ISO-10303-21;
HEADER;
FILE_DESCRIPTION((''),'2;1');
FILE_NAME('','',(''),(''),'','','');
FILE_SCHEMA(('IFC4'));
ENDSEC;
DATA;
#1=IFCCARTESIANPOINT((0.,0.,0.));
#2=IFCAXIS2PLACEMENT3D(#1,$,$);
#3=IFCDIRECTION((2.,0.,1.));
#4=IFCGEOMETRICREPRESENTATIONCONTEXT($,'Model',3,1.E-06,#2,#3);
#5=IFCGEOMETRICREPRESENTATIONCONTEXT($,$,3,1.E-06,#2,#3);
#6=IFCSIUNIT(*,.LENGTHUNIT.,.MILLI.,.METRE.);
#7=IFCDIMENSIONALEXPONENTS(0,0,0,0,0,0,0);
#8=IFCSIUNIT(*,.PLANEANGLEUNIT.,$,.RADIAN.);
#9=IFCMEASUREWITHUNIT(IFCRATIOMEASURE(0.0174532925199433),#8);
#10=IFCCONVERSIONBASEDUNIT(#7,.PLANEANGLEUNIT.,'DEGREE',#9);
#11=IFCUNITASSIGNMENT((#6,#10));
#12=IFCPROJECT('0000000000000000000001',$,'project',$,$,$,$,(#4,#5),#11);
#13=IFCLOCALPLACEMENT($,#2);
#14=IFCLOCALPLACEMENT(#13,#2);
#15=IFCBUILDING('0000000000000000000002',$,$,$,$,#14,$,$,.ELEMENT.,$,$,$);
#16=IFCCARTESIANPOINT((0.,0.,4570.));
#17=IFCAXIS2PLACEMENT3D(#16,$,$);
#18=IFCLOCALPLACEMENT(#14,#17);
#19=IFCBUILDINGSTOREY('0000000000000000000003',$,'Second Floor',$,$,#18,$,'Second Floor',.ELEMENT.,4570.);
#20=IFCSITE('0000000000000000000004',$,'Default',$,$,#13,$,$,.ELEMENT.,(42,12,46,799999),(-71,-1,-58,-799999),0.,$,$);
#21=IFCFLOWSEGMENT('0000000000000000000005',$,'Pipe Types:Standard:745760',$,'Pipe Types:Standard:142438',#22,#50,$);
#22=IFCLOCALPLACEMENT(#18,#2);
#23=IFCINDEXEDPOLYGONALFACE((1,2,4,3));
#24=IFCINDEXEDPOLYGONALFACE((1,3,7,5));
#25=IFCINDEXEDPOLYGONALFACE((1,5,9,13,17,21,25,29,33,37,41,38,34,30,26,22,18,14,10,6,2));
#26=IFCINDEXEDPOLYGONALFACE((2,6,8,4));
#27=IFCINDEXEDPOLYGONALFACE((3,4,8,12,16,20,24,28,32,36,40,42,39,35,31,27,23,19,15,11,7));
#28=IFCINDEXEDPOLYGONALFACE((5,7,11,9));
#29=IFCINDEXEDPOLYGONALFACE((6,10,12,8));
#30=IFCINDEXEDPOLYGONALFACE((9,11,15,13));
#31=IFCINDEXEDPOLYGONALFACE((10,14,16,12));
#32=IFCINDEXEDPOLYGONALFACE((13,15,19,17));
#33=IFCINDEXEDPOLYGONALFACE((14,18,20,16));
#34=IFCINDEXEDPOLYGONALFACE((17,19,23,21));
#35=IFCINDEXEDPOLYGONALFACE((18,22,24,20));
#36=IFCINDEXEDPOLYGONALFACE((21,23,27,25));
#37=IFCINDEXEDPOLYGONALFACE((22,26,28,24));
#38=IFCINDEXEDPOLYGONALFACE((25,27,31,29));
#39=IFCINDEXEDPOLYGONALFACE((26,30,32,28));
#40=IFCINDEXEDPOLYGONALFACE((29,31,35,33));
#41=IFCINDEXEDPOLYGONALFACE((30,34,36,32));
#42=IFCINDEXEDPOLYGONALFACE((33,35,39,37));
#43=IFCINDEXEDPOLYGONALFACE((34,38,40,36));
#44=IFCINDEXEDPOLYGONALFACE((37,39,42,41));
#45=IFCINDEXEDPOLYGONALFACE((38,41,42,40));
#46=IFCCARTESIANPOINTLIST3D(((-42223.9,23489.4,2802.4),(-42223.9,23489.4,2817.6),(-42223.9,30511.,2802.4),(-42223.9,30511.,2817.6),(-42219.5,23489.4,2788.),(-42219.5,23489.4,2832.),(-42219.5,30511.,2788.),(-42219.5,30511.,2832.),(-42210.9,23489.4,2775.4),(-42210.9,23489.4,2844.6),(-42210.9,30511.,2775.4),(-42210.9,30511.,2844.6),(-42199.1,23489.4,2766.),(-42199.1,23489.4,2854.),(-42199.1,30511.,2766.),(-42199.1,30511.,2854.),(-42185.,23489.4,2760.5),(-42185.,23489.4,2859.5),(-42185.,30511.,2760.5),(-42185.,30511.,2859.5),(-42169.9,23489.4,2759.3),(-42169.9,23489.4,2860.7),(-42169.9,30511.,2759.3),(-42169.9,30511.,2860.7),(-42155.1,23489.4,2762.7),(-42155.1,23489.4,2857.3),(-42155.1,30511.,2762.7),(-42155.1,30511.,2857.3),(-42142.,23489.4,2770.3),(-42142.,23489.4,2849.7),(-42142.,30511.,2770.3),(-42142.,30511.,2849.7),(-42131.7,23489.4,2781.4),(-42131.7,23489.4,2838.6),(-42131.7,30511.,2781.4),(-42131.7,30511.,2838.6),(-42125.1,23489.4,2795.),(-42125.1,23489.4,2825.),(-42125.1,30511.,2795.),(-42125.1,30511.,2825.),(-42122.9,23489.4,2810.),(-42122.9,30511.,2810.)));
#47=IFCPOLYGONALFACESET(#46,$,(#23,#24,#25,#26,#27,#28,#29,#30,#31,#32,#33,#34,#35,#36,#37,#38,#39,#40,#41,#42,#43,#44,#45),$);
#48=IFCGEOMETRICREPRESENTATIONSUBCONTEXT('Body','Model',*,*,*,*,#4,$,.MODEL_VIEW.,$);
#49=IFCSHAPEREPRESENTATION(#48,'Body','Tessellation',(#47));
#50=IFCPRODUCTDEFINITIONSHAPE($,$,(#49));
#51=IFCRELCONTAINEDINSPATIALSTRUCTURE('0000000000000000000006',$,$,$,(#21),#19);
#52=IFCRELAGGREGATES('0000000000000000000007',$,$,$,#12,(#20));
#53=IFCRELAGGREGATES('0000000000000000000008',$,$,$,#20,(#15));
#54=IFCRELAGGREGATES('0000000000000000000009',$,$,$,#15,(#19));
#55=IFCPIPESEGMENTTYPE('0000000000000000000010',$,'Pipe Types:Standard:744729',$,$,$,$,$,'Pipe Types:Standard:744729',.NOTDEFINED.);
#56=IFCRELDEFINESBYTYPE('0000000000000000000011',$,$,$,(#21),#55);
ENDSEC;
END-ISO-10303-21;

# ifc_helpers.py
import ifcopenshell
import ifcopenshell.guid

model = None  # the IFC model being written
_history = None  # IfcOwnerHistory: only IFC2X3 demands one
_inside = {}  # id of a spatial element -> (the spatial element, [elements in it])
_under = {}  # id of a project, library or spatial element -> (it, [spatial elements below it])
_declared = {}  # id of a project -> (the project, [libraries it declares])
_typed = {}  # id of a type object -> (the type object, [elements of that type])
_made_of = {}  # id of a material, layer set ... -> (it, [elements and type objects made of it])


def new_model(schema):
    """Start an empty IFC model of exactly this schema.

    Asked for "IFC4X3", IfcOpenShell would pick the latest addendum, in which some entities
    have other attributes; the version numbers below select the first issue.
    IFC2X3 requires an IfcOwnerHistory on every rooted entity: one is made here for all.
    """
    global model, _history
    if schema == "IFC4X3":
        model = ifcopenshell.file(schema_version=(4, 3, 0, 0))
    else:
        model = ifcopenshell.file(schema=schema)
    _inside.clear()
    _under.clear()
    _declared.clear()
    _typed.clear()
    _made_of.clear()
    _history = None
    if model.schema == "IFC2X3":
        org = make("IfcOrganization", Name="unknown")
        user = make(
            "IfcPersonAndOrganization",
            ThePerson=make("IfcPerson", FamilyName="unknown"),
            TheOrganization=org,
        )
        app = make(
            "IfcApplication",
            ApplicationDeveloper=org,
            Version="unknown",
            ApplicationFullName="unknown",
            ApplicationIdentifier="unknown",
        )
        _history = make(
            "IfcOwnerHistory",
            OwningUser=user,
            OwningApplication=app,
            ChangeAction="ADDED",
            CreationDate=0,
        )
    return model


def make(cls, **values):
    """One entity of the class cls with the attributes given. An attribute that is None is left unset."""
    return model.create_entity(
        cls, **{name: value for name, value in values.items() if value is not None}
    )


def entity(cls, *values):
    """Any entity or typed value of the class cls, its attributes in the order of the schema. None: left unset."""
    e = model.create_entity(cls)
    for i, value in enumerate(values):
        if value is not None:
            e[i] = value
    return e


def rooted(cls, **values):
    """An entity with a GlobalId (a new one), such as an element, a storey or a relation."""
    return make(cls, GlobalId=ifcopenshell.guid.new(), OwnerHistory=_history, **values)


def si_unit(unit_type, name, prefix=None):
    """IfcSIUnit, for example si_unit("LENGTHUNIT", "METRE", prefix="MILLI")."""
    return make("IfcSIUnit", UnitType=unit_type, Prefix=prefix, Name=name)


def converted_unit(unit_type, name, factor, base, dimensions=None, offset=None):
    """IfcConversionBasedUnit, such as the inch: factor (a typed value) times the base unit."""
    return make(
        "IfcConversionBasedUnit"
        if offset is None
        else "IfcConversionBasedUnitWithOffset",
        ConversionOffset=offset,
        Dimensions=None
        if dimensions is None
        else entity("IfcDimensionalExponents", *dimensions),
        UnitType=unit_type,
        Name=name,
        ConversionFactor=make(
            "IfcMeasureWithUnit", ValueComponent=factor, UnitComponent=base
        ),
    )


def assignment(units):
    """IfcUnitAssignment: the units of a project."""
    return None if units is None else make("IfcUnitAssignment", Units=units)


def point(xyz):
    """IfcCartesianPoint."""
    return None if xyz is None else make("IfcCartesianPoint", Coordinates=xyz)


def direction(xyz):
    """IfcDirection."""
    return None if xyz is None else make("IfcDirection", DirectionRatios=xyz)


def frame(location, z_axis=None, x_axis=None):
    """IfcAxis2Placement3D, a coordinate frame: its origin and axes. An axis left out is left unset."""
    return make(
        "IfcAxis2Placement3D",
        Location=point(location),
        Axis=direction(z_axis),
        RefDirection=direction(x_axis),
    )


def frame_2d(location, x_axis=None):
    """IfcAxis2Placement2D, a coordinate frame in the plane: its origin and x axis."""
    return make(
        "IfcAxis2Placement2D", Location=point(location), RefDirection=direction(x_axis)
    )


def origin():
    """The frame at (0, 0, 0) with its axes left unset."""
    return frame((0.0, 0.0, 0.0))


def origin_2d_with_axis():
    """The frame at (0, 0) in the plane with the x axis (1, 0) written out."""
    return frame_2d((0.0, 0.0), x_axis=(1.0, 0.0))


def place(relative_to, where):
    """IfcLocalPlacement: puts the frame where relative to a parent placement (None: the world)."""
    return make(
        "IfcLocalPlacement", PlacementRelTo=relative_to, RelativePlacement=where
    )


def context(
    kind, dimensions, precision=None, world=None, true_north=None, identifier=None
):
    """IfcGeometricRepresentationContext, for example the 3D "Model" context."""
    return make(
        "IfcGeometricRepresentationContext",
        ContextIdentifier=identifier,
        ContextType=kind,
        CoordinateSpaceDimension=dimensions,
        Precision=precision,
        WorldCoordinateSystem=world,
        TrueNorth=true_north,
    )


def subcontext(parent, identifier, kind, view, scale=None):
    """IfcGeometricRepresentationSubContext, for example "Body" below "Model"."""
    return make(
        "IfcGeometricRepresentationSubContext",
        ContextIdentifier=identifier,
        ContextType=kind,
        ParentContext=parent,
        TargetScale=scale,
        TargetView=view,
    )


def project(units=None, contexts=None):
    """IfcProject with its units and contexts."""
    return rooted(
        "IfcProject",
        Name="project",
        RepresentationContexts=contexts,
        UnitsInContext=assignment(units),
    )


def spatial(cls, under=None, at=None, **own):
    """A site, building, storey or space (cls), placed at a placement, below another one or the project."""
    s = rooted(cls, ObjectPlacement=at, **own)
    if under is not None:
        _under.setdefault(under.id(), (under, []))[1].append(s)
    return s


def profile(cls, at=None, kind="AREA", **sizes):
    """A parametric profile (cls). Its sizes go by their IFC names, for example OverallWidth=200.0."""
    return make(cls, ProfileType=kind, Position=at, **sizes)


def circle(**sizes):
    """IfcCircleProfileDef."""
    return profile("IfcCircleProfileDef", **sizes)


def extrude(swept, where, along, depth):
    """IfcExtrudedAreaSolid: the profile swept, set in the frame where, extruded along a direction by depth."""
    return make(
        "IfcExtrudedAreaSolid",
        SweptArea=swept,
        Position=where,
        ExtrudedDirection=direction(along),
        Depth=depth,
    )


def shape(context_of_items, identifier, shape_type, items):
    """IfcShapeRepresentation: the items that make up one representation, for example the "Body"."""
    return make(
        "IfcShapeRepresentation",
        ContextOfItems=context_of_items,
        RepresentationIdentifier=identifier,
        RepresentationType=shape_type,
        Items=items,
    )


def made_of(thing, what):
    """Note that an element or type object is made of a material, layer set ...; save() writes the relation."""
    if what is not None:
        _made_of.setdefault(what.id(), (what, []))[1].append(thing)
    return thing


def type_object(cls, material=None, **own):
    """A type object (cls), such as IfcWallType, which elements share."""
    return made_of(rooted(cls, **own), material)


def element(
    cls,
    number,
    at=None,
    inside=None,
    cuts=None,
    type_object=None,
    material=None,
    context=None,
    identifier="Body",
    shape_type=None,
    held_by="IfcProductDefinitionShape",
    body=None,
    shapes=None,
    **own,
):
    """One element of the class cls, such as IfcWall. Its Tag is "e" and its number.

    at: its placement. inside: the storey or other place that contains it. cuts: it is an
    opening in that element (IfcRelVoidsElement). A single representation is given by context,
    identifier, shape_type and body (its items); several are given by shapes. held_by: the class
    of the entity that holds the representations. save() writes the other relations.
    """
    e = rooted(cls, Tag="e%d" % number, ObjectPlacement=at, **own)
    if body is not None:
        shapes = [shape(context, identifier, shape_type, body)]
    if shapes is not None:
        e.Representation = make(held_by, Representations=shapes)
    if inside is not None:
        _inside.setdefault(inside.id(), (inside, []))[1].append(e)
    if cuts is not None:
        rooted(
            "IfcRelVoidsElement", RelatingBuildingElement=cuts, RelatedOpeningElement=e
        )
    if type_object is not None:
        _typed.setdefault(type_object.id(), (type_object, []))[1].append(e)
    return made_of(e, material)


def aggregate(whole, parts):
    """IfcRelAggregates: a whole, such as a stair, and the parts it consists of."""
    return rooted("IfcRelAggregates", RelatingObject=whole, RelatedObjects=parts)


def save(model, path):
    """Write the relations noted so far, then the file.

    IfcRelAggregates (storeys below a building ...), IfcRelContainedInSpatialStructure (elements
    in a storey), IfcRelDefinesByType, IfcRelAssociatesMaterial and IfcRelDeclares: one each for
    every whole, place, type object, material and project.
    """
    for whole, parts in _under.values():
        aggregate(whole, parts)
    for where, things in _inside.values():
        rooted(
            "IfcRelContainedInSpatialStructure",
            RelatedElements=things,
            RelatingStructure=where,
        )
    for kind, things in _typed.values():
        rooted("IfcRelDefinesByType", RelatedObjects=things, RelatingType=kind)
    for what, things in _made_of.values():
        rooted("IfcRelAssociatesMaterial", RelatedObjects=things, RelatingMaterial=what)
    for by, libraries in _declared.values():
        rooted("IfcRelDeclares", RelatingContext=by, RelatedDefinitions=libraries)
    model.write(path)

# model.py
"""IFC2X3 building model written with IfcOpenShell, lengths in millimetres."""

from ifc_helpers import new_model, entity, si_unit, converted_unit, direction, frame, origin, origin_2d_with_axis, place, context, subcontext, project, spatial, circle, extrude, type_object, element, save


model = new_model("IFC2X3")

# Units and contexts
model_context = context("Model", 3, precision=1e-06, world=origin(), true_north=direction((2.0, 0.0, 1.0)))
context_of_model = context(None, 3, precision=1e-06, world=origin(), true_north=direction((2.0, 0.0, 1.0)))
body_context = subcontext(model_context, "Body", "Model", "MODEL_VIEW")
ifc_project = project(units=[si_unit("LENGTHUNIT", "METRE", prefix="MILLI"), converted_unit("PLANEANGLEUNIT", "DEGREE", entity("IfcRatioMeasure", 0.0174532925199433), si_unit("PLANEANGLEUNIT", "RADIAN"), dimensions=[0, 0, 0, 0, 0, 0, 0])], contexts=[model_context, context_of_model])

# Site, building, storey
site_placement = place(None, origin())
site = spatial("IfcSite", under=ifc_project, at=site_placement, Name="Default", CompositionType="ELEMENT", RefLatitude=(42, 12, 46, 799999), RefLongitude=(-71, -1, -58, -799999), RefElevation=0.0)
building_placement = place(site_placement, origin())
building = spatial("IfcBuilding", under=site, at=building_placement, CompositionType="ELEMENT")
storey_placement = place(building_placement, frame((0.0, 0.0, 4570.0)))
storey = spatial("IfcBuildingStorey", under=building, at=storey_placement, Name="Second Floor", LongName="Second Floor", CompositionType="ELEMENT", Elevation=4570.0)

# Flow segment
pipe_segment_type = type_object("IfcPipeSegmentType", Name="Pipe Types:Standard:744729", ElementType="Pipe Types:Standard:744729", PredefinedType="NOTDEFINED")
flow_segment_1_placement = place(storey_placement, origin())
element("IfcFlowSegment", 1, at=flow_segment_1_placement, inside=storey, type_object=pipe_segment_type, Name="Pipe Types:Standard:745760", ObjectType="Pipe Types:Standard:142438", context=body_context, shape_type="SweptSolid", body=[
    extrude(circle(Radius=50.8, at=origin_2d_with_axis()), frame((-42173.7, 23489.4, 2810.0), z_axis=(0.0, 1.0, 0.0), x_axis=(1.0, 0.0, 0.0)), (0.0, 0.0, 1.0), 7021.6),
])

save(model, "model.ifc")
